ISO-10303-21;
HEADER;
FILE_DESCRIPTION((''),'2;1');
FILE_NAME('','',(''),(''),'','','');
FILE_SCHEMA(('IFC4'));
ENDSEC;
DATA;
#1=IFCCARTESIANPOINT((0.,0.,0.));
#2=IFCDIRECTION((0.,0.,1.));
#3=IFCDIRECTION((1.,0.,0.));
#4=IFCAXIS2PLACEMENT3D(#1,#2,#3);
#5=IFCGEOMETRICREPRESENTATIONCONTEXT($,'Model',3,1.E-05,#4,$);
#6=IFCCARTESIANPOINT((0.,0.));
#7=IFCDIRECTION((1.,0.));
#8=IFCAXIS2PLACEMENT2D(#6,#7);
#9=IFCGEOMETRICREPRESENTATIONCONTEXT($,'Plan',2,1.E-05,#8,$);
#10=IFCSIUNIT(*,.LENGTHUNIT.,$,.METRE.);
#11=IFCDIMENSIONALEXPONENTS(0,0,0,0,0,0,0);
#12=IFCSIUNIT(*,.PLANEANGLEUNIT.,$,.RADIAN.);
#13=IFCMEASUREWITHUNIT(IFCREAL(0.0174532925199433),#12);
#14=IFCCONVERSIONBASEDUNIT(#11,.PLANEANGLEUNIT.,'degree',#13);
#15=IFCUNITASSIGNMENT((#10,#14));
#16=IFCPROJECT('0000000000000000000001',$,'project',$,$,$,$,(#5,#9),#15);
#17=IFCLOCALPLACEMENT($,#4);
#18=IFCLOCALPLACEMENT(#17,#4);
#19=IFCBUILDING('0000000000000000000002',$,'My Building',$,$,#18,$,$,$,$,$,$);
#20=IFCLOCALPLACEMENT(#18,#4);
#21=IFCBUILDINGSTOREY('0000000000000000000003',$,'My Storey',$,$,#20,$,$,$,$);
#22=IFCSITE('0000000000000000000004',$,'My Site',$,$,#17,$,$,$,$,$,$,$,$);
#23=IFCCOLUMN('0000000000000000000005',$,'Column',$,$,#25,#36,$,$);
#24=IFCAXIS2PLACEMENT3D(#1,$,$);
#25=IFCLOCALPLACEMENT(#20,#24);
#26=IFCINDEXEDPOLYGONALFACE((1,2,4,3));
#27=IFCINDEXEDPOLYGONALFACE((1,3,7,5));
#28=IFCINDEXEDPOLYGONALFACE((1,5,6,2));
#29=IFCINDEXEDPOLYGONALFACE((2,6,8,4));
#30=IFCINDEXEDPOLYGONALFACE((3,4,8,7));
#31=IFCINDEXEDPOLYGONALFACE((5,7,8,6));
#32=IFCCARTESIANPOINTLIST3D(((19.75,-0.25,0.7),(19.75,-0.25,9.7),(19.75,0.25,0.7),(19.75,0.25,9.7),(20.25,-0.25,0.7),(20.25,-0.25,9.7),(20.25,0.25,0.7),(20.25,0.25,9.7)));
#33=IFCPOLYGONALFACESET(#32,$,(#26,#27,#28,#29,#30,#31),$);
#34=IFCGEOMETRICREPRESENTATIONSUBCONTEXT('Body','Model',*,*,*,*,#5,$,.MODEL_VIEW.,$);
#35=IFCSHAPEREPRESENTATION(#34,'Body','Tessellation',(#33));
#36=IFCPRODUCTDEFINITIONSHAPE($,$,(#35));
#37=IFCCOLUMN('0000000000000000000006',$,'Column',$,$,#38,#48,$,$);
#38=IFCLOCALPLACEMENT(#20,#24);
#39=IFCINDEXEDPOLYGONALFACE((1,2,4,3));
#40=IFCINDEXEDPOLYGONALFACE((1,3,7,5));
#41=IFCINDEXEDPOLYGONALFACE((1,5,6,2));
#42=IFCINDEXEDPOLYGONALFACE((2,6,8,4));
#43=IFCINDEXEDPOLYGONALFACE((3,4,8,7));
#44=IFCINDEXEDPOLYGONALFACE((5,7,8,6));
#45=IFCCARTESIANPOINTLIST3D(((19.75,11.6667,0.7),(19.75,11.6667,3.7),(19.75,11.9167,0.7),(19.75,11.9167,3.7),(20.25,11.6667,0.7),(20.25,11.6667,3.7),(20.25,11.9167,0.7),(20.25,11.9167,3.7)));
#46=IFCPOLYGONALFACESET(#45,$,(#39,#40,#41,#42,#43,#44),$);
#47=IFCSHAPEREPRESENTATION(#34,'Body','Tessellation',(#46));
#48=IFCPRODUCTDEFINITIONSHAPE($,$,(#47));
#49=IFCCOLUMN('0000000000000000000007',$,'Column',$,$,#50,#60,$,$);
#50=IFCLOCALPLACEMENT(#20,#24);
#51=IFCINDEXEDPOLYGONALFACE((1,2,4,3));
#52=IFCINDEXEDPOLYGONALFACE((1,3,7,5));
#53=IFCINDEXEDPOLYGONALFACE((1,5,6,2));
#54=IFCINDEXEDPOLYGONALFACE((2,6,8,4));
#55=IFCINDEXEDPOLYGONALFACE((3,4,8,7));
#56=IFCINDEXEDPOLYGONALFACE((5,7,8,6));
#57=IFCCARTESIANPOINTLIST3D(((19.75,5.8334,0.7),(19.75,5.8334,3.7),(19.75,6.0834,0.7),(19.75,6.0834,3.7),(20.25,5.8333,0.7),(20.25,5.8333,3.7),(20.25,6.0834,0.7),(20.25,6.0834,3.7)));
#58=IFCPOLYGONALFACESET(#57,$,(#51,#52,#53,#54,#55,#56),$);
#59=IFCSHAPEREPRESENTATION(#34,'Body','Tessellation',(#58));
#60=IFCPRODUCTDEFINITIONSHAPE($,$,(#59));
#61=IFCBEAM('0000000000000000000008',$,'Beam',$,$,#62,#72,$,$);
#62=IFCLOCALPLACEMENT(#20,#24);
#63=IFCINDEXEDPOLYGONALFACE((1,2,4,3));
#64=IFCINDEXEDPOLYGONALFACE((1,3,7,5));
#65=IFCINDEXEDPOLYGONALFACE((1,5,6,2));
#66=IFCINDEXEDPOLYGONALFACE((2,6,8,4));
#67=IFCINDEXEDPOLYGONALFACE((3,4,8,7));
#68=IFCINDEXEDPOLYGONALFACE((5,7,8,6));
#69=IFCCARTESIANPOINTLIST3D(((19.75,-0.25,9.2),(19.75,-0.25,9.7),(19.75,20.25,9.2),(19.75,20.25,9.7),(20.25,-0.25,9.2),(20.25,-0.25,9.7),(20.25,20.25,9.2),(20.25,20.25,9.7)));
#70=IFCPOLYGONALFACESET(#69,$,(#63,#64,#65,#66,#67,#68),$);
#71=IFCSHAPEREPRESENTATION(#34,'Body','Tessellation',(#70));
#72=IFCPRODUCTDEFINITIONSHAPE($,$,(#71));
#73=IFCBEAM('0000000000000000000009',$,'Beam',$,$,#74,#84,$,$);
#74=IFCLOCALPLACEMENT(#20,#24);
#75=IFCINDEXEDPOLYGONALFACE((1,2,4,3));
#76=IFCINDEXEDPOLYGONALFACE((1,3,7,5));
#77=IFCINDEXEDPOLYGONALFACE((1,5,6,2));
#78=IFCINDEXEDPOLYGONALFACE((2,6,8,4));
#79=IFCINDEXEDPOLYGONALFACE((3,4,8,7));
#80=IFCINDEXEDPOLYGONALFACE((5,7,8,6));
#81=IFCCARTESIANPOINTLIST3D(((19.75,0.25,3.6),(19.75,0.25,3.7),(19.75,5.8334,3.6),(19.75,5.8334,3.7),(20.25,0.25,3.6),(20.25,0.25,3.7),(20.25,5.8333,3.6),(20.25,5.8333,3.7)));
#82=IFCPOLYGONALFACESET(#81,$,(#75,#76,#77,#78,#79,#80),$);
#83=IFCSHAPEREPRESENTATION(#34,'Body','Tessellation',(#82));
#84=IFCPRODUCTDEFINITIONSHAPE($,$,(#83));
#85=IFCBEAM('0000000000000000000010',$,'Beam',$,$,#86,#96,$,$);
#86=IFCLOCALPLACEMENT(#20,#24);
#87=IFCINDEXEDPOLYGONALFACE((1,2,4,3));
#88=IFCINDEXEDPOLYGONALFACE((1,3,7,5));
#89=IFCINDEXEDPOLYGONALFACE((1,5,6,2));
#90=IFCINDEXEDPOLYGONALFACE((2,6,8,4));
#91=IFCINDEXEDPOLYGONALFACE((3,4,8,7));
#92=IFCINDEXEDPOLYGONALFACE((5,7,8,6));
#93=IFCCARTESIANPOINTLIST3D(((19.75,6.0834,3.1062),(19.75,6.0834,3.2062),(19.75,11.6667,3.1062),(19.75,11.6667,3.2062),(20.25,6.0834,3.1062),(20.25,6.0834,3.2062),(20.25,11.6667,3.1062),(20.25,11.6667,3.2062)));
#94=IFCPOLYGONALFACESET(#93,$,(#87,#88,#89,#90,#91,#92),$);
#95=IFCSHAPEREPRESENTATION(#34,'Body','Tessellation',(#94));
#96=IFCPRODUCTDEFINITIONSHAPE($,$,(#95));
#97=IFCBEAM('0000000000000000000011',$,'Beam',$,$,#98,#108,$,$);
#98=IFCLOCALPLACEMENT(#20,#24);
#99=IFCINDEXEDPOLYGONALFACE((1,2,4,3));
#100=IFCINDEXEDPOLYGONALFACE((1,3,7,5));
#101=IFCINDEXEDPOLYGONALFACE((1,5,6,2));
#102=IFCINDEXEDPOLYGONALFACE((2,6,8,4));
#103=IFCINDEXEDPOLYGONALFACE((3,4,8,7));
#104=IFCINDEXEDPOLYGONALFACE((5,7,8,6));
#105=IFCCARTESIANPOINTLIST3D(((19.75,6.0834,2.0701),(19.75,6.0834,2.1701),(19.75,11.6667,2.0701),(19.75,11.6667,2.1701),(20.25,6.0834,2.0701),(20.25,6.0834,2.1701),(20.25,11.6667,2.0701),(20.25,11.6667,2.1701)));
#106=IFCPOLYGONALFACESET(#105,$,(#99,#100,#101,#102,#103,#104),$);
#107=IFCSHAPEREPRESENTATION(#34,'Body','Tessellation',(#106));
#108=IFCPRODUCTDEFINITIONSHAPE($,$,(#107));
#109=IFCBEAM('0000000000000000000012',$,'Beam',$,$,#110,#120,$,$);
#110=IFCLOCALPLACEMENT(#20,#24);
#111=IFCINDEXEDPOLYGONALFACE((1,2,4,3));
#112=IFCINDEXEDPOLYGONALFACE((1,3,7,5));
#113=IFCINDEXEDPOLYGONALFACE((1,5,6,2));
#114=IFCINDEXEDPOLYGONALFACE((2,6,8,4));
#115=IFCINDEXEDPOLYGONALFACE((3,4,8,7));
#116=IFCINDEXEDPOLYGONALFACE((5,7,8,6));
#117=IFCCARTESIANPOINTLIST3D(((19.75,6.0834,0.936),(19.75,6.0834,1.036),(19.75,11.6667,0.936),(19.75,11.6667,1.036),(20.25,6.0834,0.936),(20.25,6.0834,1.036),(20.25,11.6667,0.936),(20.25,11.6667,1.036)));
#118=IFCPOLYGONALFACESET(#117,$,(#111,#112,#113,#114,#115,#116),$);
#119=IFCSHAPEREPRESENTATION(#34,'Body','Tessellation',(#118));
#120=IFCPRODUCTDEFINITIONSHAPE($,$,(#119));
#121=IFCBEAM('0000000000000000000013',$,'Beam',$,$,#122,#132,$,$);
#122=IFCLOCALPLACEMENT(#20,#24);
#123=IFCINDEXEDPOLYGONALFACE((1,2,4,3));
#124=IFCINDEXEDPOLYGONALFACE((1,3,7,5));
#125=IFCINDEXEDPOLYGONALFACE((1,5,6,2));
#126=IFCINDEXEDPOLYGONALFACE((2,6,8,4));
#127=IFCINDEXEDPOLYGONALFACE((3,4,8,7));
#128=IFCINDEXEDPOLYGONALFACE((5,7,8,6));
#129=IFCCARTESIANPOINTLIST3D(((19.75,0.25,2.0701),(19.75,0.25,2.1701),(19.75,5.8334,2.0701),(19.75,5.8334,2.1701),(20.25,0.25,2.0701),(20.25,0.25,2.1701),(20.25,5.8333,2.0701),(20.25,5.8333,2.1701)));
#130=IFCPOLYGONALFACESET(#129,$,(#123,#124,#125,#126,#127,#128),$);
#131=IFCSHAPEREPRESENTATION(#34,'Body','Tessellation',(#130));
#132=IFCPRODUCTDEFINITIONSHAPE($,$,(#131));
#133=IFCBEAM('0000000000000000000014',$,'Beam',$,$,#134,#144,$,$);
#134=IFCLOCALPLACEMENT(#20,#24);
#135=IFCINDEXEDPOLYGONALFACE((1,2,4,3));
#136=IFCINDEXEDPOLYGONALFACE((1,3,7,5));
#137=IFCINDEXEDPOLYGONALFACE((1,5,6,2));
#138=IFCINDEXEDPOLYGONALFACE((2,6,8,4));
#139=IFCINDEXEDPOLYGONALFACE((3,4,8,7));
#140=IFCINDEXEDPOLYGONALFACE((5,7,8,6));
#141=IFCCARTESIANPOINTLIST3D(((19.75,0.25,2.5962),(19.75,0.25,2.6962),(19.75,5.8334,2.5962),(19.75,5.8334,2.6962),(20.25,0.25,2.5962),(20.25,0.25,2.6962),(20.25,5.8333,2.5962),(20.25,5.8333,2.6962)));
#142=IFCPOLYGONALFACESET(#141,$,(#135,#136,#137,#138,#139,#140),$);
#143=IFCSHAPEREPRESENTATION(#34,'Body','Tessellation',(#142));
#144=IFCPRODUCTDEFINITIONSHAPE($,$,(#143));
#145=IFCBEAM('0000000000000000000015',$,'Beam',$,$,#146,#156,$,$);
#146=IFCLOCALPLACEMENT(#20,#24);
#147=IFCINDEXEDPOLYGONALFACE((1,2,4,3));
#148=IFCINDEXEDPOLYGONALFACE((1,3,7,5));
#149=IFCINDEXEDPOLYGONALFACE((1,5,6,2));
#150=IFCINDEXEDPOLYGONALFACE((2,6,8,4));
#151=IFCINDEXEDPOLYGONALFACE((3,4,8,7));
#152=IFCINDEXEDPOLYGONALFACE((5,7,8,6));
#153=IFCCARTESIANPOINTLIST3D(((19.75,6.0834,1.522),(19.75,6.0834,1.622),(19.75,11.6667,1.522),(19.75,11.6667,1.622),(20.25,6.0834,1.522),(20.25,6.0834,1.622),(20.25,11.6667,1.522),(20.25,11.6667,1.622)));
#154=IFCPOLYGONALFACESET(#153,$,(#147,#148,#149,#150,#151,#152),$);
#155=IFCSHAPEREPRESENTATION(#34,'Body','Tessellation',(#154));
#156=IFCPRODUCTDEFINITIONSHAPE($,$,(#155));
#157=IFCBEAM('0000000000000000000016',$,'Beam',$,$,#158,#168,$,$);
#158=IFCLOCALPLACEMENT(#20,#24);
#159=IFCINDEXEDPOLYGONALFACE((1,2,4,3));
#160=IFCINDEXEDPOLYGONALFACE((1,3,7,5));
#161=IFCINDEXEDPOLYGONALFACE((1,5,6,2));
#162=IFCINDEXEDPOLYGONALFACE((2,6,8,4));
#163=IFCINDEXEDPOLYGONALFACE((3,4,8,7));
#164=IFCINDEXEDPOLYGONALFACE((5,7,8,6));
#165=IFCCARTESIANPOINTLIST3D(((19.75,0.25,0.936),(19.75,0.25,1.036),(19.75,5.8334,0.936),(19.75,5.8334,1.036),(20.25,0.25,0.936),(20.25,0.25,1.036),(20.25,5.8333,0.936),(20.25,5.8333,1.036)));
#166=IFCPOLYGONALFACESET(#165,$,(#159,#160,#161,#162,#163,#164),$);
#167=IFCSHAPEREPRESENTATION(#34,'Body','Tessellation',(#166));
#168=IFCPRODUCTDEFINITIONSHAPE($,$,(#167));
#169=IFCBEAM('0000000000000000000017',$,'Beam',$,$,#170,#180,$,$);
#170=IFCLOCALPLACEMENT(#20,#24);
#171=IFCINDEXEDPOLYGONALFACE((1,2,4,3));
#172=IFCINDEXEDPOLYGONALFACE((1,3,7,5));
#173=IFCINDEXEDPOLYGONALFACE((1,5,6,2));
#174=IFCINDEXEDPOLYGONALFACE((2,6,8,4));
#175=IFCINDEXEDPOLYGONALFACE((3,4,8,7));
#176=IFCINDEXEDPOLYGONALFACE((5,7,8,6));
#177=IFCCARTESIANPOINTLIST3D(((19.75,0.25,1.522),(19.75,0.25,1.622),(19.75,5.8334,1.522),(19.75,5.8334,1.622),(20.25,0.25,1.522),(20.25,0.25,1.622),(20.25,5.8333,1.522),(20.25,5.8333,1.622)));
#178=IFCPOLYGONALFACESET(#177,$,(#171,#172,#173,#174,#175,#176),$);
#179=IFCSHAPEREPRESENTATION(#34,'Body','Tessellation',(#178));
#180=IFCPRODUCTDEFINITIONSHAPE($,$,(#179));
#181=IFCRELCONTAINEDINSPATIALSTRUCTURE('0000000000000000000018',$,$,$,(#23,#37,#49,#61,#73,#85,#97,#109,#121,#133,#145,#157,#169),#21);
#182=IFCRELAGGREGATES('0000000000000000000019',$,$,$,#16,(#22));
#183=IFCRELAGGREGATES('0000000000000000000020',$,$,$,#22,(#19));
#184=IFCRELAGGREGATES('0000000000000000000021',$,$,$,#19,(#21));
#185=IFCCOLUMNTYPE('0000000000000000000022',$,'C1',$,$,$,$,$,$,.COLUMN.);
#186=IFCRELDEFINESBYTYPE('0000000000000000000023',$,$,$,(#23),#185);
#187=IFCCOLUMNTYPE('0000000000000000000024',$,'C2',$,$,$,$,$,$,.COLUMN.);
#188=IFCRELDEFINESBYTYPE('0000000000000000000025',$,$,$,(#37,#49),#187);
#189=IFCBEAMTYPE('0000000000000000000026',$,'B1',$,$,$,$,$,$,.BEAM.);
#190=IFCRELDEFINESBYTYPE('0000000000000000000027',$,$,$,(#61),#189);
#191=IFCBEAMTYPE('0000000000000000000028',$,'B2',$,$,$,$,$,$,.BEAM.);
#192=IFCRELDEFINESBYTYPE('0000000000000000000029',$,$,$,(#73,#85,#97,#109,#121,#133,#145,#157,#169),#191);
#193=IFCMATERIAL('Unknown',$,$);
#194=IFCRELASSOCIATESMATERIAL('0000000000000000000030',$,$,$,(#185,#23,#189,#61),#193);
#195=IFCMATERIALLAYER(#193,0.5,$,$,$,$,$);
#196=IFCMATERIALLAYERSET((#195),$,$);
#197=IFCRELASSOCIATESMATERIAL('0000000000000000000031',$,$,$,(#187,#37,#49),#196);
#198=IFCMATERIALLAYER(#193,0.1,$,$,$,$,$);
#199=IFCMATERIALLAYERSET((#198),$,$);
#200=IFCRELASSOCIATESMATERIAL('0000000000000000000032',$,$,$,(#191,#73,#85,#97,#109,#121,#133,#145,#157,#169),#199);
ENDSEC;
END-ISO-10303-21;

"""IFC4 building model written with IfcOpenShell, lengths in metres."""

from ifc_helpers import new_model, entity, si_unit, converted_unit, frame, origin_with_axes, origin_2d_with_axis, place, context, subcontext, project, spatial, line, indexed_curve, rectangle, outline, extrude, material, layer, layer_set, layer_usage, material_profile, profile_set, profile_usage, type_object, element, save


model = new_model("IFC4")

# Units and contexts
model_context = context("Model", 3, precision=1e-05, world=origin_with_axes())
plan_context = context("Plan", 2, precision=1e-05, world=origin_2d_with_axis())
body_context = subcontext(model_context, "Body", "Model", "MODEL_VIEW")
ifc_project = project(units=[si_unit("LENGTHUNIT", "METRE"), converted_unit("PLANEANGLEUNIT", "degree", entity("IfcReal", 0.0174532925199433), si_unit("PLANEANGLEUNIT", "RADIAN"), dimensions=[0, 0, 0, 0, 0, 0, 0])], contexts=[model_context, plan_context])

# Site, building, storey
site_placement = place(None, origin_with_axes())
site = spatial("IfcSite", under=ifc_project, at=site_placement, Name="My Site")
building_placement = place(site_placement, origin_with_axes())
building = spatial("IfcBuilding", under=site, at=building_placement, Name="My Building")
storey_placement = place(building_placement, origin_with_axes())
storey = spatial("IfcBuildingStorey", under=building, at=storey_placement, Name="My Storey")

# Columns
ifc_material = material(Name="Unknown")
ifc_material_profile_1 = material_profile(ifc_material, rectangle(XDim=0.5, YDim=0.5))
ifc_profile_set_1 = profile_set([ifc_material_profile_1])
ifc_profile_usage_1 = profile_usage(ifc_profile_set_1, cardinal=5)
column_type_1 = type_object("IfcColumnType", Name="C1", PredefinedType="COLUMN", material=ifc_profile_set_1)
column_1_placement = place(storey_placement, frame((20.0, 0.0, 0.7), z_axis=(0.0, 0.0, 1.0), x_axis=(1.0, 0.0, 0.0)))
element("IfcColumn", 1, at=column_1_placement, inside=storey, type_object=column_type_1, material=ifc_profile_usage_1, Name="Column", context=body_context, shape_type="SweptSolid", body=[
    extrude(rectangle(XDim=0.5, YDim=0.5), origin_with_axes(), (0.0, 0.0, 1.0), 9.0),
])
ifc_layer_1 = layer(ifc_material, 0.5)
ifc_layer_set_1 = layer_set([ifc_layer_1])
ifc_layer_usage_1 = layer_usage(ifc_layer_set_1, "AXIS2", "POSITIVE", 0.0)
column_type_2 = type_object("IfcColumnType", Name="C2", PredefinedType="COLUMN", material=ifc_layer_set_1)
column_2_placement = place(storey_placement, frame((20.25, 11.6667, 0.7), z_axis=(0.0, 0.0, 1.0), x_axis=(0.000007, 1.0, 0.0)))
element("IfcColumn", 2, at=column_2_placement, inside=storey, type_object=column_type_2, material=ifc_layer_usage_1, Name="Column", context=body_context, shape_type="SweptSolid", body=[
    extrude(outline(indexed_curve([(0.0, 0.0), (0.0, 0.5), (0.25, 0.5), (0.25, 0.0)], segments=[line(1, 2, 3, 4, 1)])), origin_with_axes(), (0.0, 0.0, 1.0), 3.0),
])
ifc_layer_usage_2 = layer_usage(ifc_layer_set_1, "AXIS2", "POSITIVE", 0.0)
column_3_placement = place(storey_placement, frame((20.25, 5.8333, 0.7), z_axis=(0.0, 0.0, 1.0), x_axis=(0.000007, 1.0, 0.0)))
element("IfcColumn", 3, at=column_3_placement, inside=storey, type_object=column_type_2, material=ifc_layer_usage_2, Name="Column", context=body_context, shape_type="SweptSolid", body=[
    extrude(outline(indexed_curve([(0.0, 0.0), (0.0, 0.5), (0.25, 0.5), (0.25, 0.0)], segments=[line(1, 2, 3, 4, 1)])), origin_with_axes(), (0.0, 0.0, 1.0), 3.0),
])

# Beams
ifc_material_profile_2 = material_profile(ifc_material, rectangle(XDim=0.5, YDim=0.5))
ifc_profile_set_2 = profile_set([ifc_material_profile_2])
ifc_profile_usage_2 = profile_usage(ifc_profile_set_2, cardinal=8)
beam_type_1 = type_object("IfcBeamType", Name="B1", PredefinedType="BEAM", material=ifc_profile_set_2)
beam_1_placement = place(storey_placement, frame((20.0, -0.25, 9.7), z_axis=(0.0, 1.0, 0.0), x_axis=(-1.0, 0.0, 0.0)))
element("IfcBeam", 4, at=beam_1_placement, inside=storey, type_object=beam_type_1, material=ifc_profile_usage_2, Name="Beam", context=body_context, shape_type="SweptSolid", body=[
    extrude(rectangle(XDim=0.5, YDim=0.5), frame((0.0, -0.25, 0.0), z_axis=(0.0, 0.0, 1.0), x_axis=(1.0, 0.0, 0.0)), (0.0, 0.0, 1.0), 20.5),
])
ifc_layer_2 = layer(ifc_material, 0.1)
ifc_layer_set_2 = layer_set([ifc_layer_2])
ifc_layer_usage_3 = layer_usage(ifc_layer_set_2, "AXIS3", "POSITIVE", -0.1)
beam_type_2 = type_object("IfcBeamType", Name="B2", PredefinedType="BEAM", material=ifc_layer_set_2)
beam_2_placement = place(storey_placement, frame((19.75, 0.25, 3.7), z_axis=(0.0, 0.0, 1.0), x_axis=(0.0, 1.0, 0.0)))
element("IfcBeam", 5, at=beam_2_placement, inside=storey, type_object=beam_type_2, material=ifc_layer_usage_3, Name="Beam", context=body_context, shape_type="SweptSolid", body=[
    extrude(outline(indexed_curve([(0.0, 0.0), (0.0, -0.5), (5.5833, -0.5), (5.5834, 0.0), (0.0, 0.0)])), frame((0.0, 0.0, -0.1), z_axis=(0.0, 0.0, 1.0), x_axis=(1.0, 0.0, 0.0)), (0.0, 0.0, 1.0), 0.1),
])
ifc_layer_usage_4 = layer_usage(ifc_layer_set_2, "AXIS3", "POSITIVE", -0.1)
beam_3_placement = place(storey_placement, frame((19.75, 6.0834, 3.2062), z_axis=(0.0, 0.0, 1.0), x_axis=(0.0, 1.0, 0.0)))
element("IfcBeam", 6, at=beam_3_placement, inside=storey, type_object=beam_type_2, material=ifc_layer_usage_4, Name="Beam", context=body_context, shape_type="SweptSolid", body=[
    extrude(outline(indexed_curve([(0.0, 0.0), (0.0, -0.5), (5.5833, -0.5), (5.5834, 0.0), (0.0, 0.0)])), frame((0.0, 0.0, -0.1), z_axis=(0.0, 0.0, 1.0), x_axis=(1.0, 0.0, 0.0)), (0.0, 0.0, 1.0), 0.1),
])
ifc_layer_usage_5 = layer_usage(ifc_layer_set_2, "AXIS3", "POSITIVE", -0.1)
beam_4_placement = place(storey_placement, frame((19.75, 6.0834, 2.1701), z_axis=(0.0, 0.0, 1.0), x_axis=(0.0, 1.0, 0.0)))
element("IfcBeam", 7, at=beam_4_placement, inside=storey, type_object=beam_type_2, material=ifc_layer_usage_5, Name="Beam", context=body_context, shape_type="SweptSolid", body=[
    extrude(outline(indexed_curve([(0.0, 0.0), (0.0, -0.5), (5.5833, -0.5), (5.5834, 0.0), (0.0, 0.0)])), frame((0.0, 0.0, -0.1), z_axis=(0.0, 0.0, 1.0), x_axis=(1.0, 0.0, 0.0)), (0.0, 0.0, 1.0), 0.1),
])
ifc_layer_usage_6 = layer_usage(ifc_layer_set_2, "AXIS3", "POSITIVE", -0.1)
beam_5_placement = place(storey_placement, frame((19.75, 6.0834, 1.036), z_axis=(0.0, 0.0, 1.0), x_axis=(0.0, 1.0, 0.0)))
element("IfcBeam", 8, at=beam_5_placement, inside=storey, type_object=beam_type_2, material=ifc_layer_usage_6, Name="Beam", context=body_context, shape_type="SweptSolid", body=[
    extrude(outline(indexed_curve([(0.0, 0.0), (0.0, -0.5), (5.5833, -0.5), (5.5834, 0.0), (0.0, 0.0)])), frame((0.0, 0.0, -0.1), z_axis=(0.0, 0.0, 1.0), x_axis=(1.0, 0.0, 0.0)), (0.0, 0.0, 1.0), 0.1),
])
ifc_layer_usage_7 = layer_usage(ifc_layer_set_2, "AXIS3", "POSITIVE", -0.1)
beam_6_placement = place(storey_placement, frame((19.75, 0.25, 2.1701), z_axis=(0.0, 0.0, 1.0), x_axis=(0.0, 1.0, 0.0)))
element("IfcBeam", 9, at=beam_6_placement, inside=storey, type_object=beam_type_2, material=ifc_layer_usage_7, Name="Beam", context=body_context, shape_type="SweptSolid", body=[
    extrude(outline(indexed_curve([(0.0, 0.0), (0.0, -0.5), (5.5833, -0.5), (5.5834, 0.0), (0.0, 0.0)])), frame((0.0, 0.0, -0.1), z_axis=(0.0, 0.0, 1.0), x_axis=(1.0, 0.0, 0.0)), (0.0, 0.0, 1.0), 0.1),
])
ifc_layer_usage_8 = layer_usage(ifc_layer_set_2, "AXIS3", "POSITIVE", -0.1)
beam_7_placement = place(storey_placement, frame((19.75, 0.25, 2.6962), z_axis=(0.0, 0.0, 1.0), x_axis=(0.0, 1.0, 0.0)))
element("IfcBeam", 10, at=beam_7_placement, inside=storey, type_object=beam_type_2, material=ifc_layer_usage_8, Name="Beam", context=body_context, shape_type="SweptSolid", body=[
    extrude(outline(indexed_curve([(0.0, 0.0), (0.0, -0.5), (5.5833, -0.5), (5.5834, 0.0), (0.0, 0.0)])), frame((0.0, 0.0, -0.1), z_axis=(0.0, 0.0, 1.0), x_axis=(1.0, 0.0, 0.0)), (0.0, 0.0, 1.0), 0.1),
])
ifc_layer_usage_9 = layer_usage(ifc_layer_set_2, "AXIS3", "POSITIVE", -0.1)
beam_8_placement = place(storey_placement, frame((19.75, 6.0834, 1.622), z_axis=(0.0, 0.0, 1.0), x_axis=(0.0, 1.0, 0.0)))
element("IfcBeam", 11, at=beam_8_placement, inside=storey, type_object=beam_type_2, material=ifc_layer_usage_9, Name="Beam", context=body_context, shape_type="SweptSolid", body=[
    extrude(outline(indexed_curve([(0.0, 0.0), (0.0, -0.5), (5.5833, -0.5), (5.5834, 0.0), (0.0, 0.0)])), frame((0.0, 0.0, -0.1), z_axis=(0.0, 0.0, 1.0), x_axis=(1.0, 0.0, 0.0)), (0.0, 0.0, 1.0), 0.1),
])
ifc_layer_usage_10 = layer_usage(ifc_layer_set_2, "AXIS3", "POSITIVE", -0.1)
beam_9_placement = place(storey_placement, frame((19.75, 0.25, 1.036), z_axis=(0.0, 0.0, 1.0), x_axis=(0.0, 1.0, 0.0)))
element("IfcBeam", 12, at=beam_9_placement, inside=storey, type_object=beam_type_2, material=ifc_layer_usage_10, Name="Beam", context=body_context, shape_type="SweptSolid", body=[
    extrude(outline(indexed_curve([(0.0, 0.0), (0.0, -0.5), (5.5833, -0.5), (5.5834, 0.0), (0.0, 0.0)])), frame((0.0, 0.0, -0.1), z_axis=(0.0, 0.0, 1.0), x_axis=(1.0, 0.0, 0.0)), (0.0, 0.0, 1.0), 0.1),
])
ifc_layer_usage_11 = layer_usage(ifc_layer_set_2, "AXIS3", "POSITIVE", -0.1)
beam_10_placement = place(storey_placement, frame((19.75, 0.25, 1.622), z_axis=(0.0, 0.0, 1.0), x_axis=(0.0, 1.0, 0.0)))
element("IfcBeam", 13, at=beam_10_placement, inside=storey, type_object=beam_type_2, material=ifc_layer_usage_11, Name="Beam", context=body_context, shape_type="SweptSolid", body=[
    extrude(outline(indexed_curve([(0.0, 0.0), (0.0, -0.5), (5.5833, -0.5), (5.5834, 0.0), (0.0, 0.0)])), frame((0.0, 0.0, -0.1), z_axis=(0.0, 0.0, 1.0), x_axis=(1.0, 0.0, 0.0)), (0.0, 0.0, 1.0), 0.1),
])

save(model, "model.ifc")
